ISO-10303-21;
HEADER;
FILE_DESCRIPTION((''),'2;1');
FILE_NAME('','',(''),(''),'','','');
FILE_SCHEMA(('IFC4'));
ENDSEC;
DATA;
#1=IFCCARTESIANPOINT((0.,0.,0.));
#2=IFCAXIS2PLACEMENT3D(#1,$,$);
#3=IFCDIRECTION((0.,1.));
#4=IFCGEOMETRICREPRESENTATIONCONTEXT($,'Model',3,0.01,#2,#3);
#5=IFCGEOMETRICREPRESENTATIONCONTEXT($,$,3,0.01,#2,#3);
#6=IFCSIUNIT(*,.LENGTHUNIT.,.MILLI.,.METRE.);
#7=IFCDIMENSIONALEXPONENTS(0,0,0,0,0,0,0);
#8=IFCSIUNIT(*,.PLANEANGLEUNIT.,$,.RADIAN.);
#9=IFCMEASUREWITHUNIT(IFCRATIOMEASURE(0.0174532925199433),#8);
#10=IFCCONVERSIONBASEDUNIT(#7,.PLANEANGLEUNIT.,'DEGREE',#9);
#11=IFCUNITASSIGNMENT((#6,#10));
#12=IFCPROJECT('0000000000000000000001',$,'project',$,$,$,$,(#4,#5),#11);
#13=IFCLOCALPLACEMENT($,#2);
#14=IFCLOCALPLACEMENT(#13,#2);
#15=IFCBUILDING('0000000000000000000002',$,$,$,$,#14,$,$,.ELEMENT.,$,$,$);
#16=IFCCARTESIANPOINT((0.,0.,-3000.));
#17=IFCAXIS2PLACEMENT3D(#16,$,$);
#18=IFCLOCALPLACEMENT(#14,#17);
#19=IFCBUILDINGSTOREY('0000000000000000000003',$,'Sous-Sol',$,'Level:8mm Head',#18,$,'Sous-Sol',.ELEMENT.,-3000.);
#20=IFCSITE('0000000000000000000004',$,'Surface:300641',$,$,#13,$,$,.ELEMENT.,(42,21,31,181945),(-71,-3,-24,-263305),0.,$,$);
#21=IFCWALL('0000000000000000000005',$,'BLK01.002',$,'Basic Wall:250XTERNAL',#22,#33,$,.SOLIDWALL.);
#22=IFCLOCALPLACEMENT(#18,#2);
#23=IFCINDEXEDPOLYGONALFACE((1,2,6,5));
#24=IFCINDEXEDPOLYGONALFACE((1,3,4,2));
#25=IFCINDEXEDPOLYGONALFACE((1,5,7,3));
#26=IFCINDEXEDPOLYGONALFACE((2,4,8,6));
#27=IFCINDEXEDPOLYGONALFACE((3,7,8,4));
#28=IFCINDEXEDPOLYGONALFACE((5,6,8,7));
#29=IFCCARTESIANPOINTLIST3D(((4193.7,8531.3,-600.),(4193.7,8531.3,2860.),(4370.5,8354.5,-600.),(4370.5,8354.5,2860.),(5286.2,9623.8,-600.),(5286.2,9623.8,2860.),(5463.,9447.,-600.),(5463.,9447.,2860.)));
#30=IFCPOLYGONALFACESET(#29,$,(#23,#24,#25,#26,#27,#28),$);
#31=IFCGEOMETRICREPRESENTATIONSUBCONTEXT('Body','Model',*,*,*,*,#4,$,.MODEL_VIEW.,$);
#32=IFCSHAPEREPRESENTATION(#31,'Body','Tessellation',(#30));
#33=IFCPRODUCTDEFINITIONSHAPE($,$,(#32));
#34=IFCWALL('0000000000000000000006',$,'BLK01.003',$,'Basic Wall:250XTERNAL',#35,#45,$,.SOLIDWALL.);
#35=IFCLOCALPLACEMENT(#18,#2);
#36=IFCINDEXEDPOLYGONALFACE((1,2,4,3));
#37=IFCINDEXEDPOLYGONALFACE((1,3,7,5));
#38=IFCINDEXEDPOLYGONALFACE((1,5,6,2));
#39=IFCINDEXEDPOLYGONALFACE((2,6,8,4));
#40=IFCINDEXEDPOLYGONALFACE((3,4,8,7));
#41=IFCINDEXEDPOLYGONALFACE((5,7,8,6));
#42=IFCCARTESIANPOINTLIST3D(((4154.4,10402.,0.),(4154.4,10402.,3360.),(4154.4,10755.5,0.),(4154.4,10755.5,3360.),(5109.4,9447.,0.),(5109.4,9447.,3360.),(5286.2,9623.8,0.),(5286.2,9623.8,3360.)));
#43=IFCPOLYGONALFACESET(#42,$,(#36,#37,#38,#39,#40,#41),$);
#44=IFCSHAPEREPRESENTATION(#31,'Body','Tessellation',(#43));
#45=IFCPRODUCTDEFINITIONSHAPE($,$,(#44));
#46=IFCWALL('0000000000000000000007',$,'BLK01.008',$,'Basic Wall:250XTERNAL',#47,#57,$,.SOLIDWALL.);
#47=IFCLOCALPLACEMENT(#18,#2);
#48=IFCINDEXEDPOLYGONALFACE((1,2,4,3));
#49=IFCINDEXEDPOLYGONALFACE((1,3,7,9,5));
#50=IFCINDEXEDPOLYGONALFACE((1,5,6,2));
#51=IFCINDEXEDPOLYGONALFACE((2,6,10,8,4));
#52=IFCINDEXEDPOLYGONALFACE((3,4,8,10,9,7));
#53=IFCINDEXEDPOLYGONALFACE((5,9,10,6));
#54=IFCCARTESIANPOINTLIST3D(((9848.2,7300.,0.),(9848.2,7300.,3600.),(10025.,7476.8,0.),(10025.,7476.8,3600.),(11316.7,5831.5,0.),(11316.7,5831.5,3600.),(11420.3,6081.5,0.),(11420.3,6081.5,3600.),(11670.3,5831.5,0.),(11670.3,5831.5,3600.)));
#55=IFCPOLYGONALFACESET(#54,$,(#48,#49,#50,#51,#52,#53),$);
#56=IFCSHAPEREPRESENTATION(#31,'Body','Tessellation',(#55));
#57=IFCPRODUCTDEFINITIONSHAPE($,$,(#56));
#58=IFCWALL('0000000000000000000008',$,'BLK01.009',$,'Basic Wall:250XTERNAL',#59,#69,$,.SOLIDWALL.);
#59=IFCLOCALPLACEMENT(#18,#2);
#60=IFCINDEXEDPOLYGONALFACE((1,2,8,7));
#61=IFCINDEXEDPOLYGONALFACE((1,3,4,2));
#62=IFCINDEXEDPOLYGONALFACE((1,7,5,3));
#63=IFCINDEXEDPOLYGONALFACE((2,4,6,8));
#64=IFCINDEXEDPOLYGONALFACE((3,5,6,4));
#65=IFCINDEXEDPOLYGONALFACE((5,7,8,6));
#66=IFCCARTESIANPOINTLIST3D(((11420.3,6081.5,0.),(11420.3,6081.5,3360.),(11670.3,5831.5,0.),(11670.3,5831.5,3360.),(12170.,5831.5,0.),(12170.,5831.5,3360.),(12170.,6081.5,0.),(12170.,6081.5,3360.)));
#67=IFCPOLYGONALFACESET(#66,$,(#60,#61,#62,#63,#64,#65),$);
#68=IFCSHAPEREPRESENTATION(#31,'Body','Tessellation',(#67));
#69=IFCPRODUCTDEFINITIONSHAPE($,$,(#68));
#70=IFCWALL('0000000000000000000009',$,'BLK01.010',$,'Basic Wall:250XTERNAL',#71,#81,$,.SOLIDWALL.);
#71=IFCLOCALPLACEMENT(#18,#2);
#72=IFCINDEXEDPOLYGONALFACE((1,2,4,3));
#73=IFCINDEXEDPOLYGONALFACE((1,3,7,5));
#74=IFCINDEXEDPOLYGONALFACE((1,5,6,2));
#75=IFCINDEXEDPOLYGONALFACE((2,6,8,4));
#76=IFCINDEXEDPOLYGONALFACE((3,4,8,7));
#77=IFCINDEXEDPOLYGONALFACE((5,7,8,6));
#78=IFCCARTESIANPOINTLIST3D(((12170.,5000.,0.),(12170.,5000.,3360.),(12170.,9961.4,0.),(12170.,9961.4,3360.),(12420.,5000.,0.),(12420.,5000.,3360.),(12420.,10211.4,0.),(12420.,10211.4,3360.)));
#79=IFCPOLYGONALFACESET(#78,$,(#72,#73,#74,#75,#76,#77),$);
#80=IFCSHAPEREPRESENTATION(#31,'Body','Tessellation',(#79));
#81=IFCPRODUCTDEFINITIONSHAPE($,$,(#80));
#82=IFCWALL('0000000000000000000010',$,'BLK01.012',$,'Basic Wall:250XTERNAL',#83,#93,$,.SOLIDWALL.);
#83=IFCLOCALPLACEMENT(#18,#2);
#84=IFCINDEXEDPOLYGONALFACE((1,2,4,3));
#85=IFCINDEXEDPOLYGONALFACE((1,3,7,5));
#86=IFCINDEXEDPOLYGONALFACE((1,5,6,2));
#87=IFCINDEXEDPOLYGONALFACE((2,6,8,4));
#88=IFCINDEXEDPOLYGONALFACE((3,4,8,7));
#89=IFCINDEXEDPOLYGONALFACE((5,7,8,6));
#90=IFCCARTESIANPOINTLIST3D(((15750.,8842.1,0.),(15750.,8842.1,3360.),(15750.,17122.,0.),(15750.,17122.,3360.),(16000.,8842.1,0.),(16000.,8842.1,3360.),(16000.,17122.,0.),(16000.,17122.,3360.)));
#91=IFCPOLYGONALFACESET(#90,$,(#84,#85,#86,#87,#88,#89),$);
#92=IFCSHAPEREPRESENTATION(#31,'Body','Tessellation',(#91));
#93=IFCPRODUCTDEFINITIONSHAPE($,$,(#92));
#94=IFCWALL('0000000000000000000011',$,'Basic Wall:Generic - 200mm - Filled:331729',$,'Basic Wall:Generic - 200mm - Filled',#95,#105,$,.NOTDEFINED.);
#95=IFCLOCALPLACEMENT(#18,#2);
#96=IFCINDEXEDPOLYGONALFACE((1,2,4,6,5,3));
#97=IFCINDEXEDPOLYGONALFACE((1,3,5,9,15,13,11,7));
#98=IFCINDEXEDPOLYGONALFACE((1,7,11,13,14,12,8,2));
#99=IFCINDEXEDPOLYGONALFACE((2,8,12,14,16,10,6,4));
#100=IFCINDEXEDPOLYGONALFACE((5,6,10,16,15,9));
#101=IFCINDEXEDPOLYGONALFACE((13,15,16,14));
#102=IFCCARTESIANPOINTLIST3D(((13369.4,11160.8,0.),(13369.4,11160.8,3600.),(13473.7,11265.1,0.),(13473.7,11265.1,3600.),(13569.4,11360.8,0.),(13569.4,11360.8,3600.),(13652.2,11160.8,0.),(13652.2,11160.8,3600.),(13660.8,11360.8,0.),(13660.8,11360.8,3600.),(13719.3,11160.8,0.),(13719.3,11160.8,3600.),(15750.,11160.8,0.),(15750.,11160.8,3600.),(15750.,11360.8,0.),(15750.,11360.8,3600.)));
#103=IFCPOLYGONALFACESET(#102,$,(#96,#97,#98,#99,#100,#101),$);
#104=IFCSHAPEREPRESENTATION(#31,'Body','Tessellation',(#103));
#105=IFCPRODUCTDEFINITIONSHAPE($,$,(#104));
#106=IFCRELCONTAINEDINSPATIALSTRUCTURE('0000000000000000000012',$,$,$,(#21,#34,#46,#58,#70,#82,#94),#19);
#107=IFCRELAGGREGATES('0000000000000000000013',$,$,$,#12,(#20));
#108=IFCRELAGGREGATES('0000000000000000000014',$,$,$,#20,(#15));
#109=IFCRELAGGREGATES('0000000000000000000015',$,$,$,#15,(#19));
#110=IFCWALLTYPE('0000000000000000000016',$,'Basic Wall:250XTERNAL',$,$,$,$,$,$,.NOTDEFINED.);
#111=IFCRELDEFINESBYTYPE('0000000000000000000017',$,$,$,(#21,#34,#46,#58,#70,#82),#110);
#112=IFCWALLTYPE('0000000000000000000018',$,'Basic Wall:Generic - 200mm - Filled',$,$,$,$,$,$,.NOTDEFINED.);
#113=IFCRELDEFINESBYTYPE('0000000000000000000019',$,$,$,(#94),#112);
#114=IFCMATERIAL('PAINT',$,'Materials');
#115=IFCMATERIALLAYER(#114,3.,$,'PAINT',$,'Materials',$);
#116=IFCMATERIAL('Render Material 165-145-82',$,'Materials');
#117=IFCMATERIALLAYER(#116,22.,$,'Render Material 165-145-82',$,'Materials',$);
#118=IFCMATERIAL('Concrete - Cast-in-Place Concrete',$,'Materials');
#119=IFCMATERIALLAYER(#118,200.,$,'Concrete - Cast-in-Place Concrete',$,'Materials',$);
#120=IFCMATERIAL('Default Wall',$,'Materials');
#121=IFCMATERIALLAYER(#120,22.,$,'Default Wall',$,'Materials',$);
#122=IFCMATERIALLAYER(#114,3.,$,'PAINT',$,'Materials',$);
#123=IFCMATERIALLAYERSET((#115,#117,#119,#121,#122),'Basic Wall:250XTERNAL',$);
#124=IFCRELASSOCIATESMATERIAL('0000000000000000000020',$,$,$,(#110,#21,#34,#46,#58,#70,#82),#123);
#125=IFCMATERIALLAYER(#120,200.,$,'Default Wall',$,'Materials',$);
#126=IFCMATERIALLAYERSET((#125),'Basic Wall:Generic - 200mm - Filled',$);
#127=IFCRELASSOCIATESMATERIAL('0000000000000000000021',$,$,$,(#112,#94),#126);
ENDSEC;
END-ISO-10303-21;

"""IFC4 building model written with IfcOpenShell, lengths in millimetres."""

from ifc_helpers import new_model, entity, si_unit, converted_unit, direction, frame, frame_2d, origin, place, context, subcontext, project, spatial, polyline, rectangle, outline, extrude, clip, halfspace, bounded_halfspace, material, layer, layer_set, layer_usage, type_object, element, save


model = new_model("IFC4")

# Units and contexts
model_context = context("Model", 3, precision=0.01, world=origin(), true_north=direction((0.0, 1.0)))
context_of_model = context(None, 3, precision=0.01, world=origin(), true_north=direction((0.0, 1.0)))
body_context = subcontext(model_context, "Body", "Model", "MODEL_VIEW")
ifc_project = project(units=[si_unit("LENGTHUNIT", "METRE", prefix="MILLI"), converted_unit("PLANEANGLEUNIT", "DEGREE", entity("IfcRatioMeasure", 0.0174532925199433), si_unit("PLANEANGLEUNIT", "RADIAN"), dimensions=[0, 0, 0, 0, 0, 0, 0])], contexts=[model_context, context_of_model])

# Site, building, storey
site_placement = place(None, origin())
site = spatial("IfcSite", under=ifc_project, at=site_placement, Name="Surface:300641", CompositionType="ELEMENT", RefLatitude=(42, 21, 31, 181945), RefLongitude=(-71, -3, -24, -263305), RefElevation=0.0)
building_placement = place(site_placement, origin())
building = spatial("IfcBuilding", under=site, at=building_placement, CompositionType="ELEMENT")
storey_placement = place(building_placement, frame((0.0, 0.0, -3000.0)))
storey = spatial("IfcBuildingStorey", under=building, at=storey_placement, Name="Sous-Sol", ObjectType="Level:8mm Head", LongName="Sous-Sol", CompositionType="ELEMENT", Elevation=-3000.0)

# Walls
ifc_material_1 = material(Name="PAINT", Category="Materials")
ifc_layer_1 = layer(ifc_material_1, 3.0, Name="PAINT", Category="Materials")
ifc_material_2 = material(Name="Render Material 165-145-82", Category="Materials")
ifc_layer_2 = layer(ifc_material_2, 22.0, Name="Render Material 165-145-82", Category="Materials")
ifc_material_3 = material(Name="Concrete - Cast-in-Place Concrete", Category="Materials")
ifc_layer_3 = layer(ifc_material_3, 200.0, Name="Concrete - Cast-in-Place Concrete", Category="Materials")
ifc_material_4 = material(Name="Default Wall", Category="Materials")
ifc_layer_4 = layer(ifc_material_4, 22.0, Name="Default Wall", Category="Materials")
ifc_layer_5 = layer(ifc_material_1, 3.0, Name="PAINT", Category="Materials")
ifc_layer_set_1 = layer_set([ifc_layer_1, ifc_layer_2, ifc_layer_3, ifc_layer_4, ifc_layer_5], Name="Basic Wall:250XTERNAL")
ifc_layer_usage_1 = layer_usage(ifc_layer_set_1, "AXIS2", "NEGATIVE", 125.0)
wall_type_1 = type_object("IfcWallType", Name="Basic Wall:250XTERNAL", PredefinedType="NOTDEFINED", material=ifc_layer_set_1)
wall_1_placement = place(storey_placement, frame((4282.1, 8442.9, -600.0), z_axis=(0.0, 0.0, 1.0), x_axis=(0.707107, 0.707107, 0.0)))
element("IfcWall", 1, at=wall_1_placement, inside=storey, type_object=wall_type_1, material=ifc_layer_usage_1, Name="BLK01.002", ObjectType="Basic Wall:250XTERNAL", PredefinedType="SOLIDWALL", context=body_context, shape_type="Clipping", body=[
    clip(extrude(rectangle(XDim=1545.0, YDim=250.0, at=frame_2d((772.5, 0.0), x_axis=(-1.0, 0.0))), origin(), (0.0, 0.0, 1.0), 3460.0), bounded_halfspace(frame((0.0, -125.0, 3460.0), z_axis=(0.0, 0.0, -1.0), x_axis=(0.707107, -0.707107, 0.0)), True, frame((0.0, -125.0, 3460.0)), polyline([(0.0, 0.0), (1545.0, 0.0), (1545.0, 250.0), (0.0, 250.0), (0.0, 0.0)]))),
])
ifc_layer_usage_2 = layer_usage(ifc_layer_set_1, "AXIS2", "NEGATIVE", 125.0)
wall_2_placement = place(storey_placement, frame((5374.6, 9358.6, 0.0), z_axis=(0.0, 0.0, 1.0), x_axis=(-0.707107, 0.707107, 0.0)))
element("IfcWall", 2, at=wall_2_placement, inside=storey, type_object=wall_type_1, material=ifc_layer_usage_2, Name="BLK01.003", ObjectType="Basic Wall:250XTERNAL", PredefinedType="SOLIDWALL", context=body_context, shape_type="Clipping", body=[
    clip(extrude(outline(polyline([(1850.5, -125.0), (1600.5, 125.0), (250.0, 125.0), (250.0, -125.0), (1850.5, -125.0)])), origin(), (0.0, 0.0, 1.0), 3360.0), bounded_halfspace(frame((250.0, -125.0, 3360.0), z_axis=(0.0, 0.0, -1.0), x_axis=(-0.707107, 0.707107, 0.0)), True, frame((250.0, -125.0, 3360.0)), polyline([(0.0, 0.0), (1600.5, 0.0), (1350.5, 250.0), (0.0, 250.0), (0.0, 0.0)]))),
])

# Walls
ifc_layer_usage_3 = layer_usage(ifc_layer_set_1, "AXIS2", "NEGATIVE", 125.0)
wall_3_placement = place(storey_placement, frame((9936.6, 7388.4, 0.0), z_axis=(0.0, 0.0, 1.0), x_axis=(0.707107, -0.707107, 0.0)))
element("IfcWall", 3, at=wall_3_placement, inside=storey, type_object=wall_type_1, material=ifc_layer_usage_3, Name="BLK01.008", ObjectType="Basic Wall:250XTERNAL", PredefinedType="SOLIDWALL", context=body_context, shape_type="SweptSolid", body=[
    extrude(outline(polyline([(2076.8, -125.0), (2326.8, 125.0), (1973.2, 125.0), (0.0, 125.0), (0.0, -125.0), (2076.8, -125.0)])), origin(), (0.0, 0.0, 1.0), 3600.0),
])
ifc_layer_usage_4 = layer_usage(ifc_layer_set_1, "AXIS2", "NEGATIVE", 125.0)
wall_4_placement = place(storey_placement, frame((11420.3, 5956.5, 0.0)))
element("IfcWall", 4, at=wall_4_placement, inside=storey, type_object=wall_type_1, material=ifc_layer_usage_4, Name="BLK01.009", ObjectType="Basic Wall:250XTERNAL", PredefinedType="SOLIDWALL", context=body_context, shape_type="Clipping", body=[
    clip(extrude(outline(polyline([(749.7, -125.0), (749.7, 125.0), (0.0, 125.0), (250.0, -125.0), (749.7, -125.0)])), origin(), (0.0, 0.0, 1.0), 3360.0), bounded_halfspace(frame((250.0, -125.0, 3360.0), z_axis=(0.0, 0.0, -1.0), x_axis=(0.0, -1.0, 0.0)), True, frame((250.0, -125.0, 3360.0)), polyline([(0.0, 0.0), (499.7, 0.0), (499.7, 250.0), (-250.0, 250.0), (0.0, 0.0)]))),
])
ifc_layer_usage_5 = layer_usage(ifc_layer_set_1, "AXIS2", "NEGATIVE", 125.0)
wall_5_placement = place(storey_placement, frame((12295.0, 5000.0, 0.0), z_axis=(0.0, 0.0, 1.0), x_axis=(0.0, 1.0, 0.0)))
element("IfcWall", 5, at=wall_5_placement, inside=storey, type_object=wall_type_1, material=ifc_layer_usage_5, Name="BLK01.010", ObjectType="Basic Wall:250XTERNAL", PredefinedType="SOLIDWALL", context=body_context, shape_type="Clipping", body=[
    clip(extrude(outline(polyline([(5211.4, -125.0), (4961.4, 125.0), (1081.5, 125.0), (831.5, 125.0), (0.0, 125.0), (0.0, -125.0), (150.0, -125.0), (4928.6, -125.0), (5211.4, -125.0)])), origin(), (0.0, 0.0, 1.0), 3360.0), bounded_halfspace(frame((0.0, -125.0, 3360.0), z_axis=(0.0, 0.0, -1.0), x_axis=(-1.0, 0.0, 0.0)), True, frame((0.0, -125.0, 3360.0)), polyline([(0.0, 0.0), (150.0, 0.0), (5211.4, 0.0), (4961.4, 250.0), (1081.5, 250.0), (831.5, 250.0), (0.0, 250.0), (0.0, 0.0)]))),
])
ifc_layer_usage_6 = layer_usage(ifc_layer_set_1, "AXIS2", "NEGATIVE", 125.0)
wall_6_placement = place(storey_placement, frame((15875.0, 8842.1, 0.0), z_axis=(0.0, 0.0, 1.0), x_axis=(0.0, 1.0, 0.0)))
element("IfcWall", 6, at=wall_6_placement, inside=storey, type_object=wall_type_1, material=ifc_layer_usage_6, Name="BLK01.012", ObjectType="Basic Wall:250XTERNAL", PredefinedType="SOLIDWALL", context=body_context, shape_type="Clipping", body=[
    clip(clip(extrude(rectangle(XDim=8279.9, YDim=250.0, at=frame_2d((4140.0, 0.0), x_axis=(-1.0, 0.0))), origin(), (0.0, 0.0, 1.0), 3360.0), bounded_halfspace(frame((0.0, 125.0, 3360.0), z_axis=(0.0, 0.0, -1.0), x_axis=(-1.0, 0.0, 0.0)), True, frame((0.0, 125.0, 3360.0)), polyline([(0.0, 0.0), (0.0, -250.0), (8279.9, -250.0), (8279.9, 0.0), (0.0, 0.0)]))), halfspace(origin(), True)),
])
ifc_layer_6 = layer(ifc_material_4, 200.0, Name="Default Wall", Category="Materials")
ifc_layer_set_2 = layer_set([ifc_layer_6], Name="Basic Wall:Generic - 200mm - Filled")
ifc_layer_usage_7 = layer_usage(ifc_layer_set_2, "AXIS2", "NEGATIVE", 100.0)
wall_type_2 = type_object("IfcWallType", Name="Basic Wall:Generic - 200mm - Filled", PredefinedType="NOTDEFINED", material=ifc_layer_set_2)
wall_7_placement = place(storey_placement, frame((13369.4, 11260.8, 0.0)))
element("IfcWall", 7, at=wall_7_placement, inside=storey, type_object=wall_type_2, material=ifc_layer_usage_7, Name="Basic Wall:Generic - 200mm - Filled:331729", ObjectType="Basic Wall:Generic - 200mm - Filled", PredefinedType="NOTDEFINED", context=body_context, shape_type="SweptSolid", body=[
    extrude(outline(polyline([(2380.6, -100.0), (2380.6, 100.0), (291.4, 100.0), (200.0, 100.0), (104.3, 4.3), (0.0, -100.0), (282.8, -100.0), (349.9, -100.0), (2380.6, -100.0)])), origin(), (0.0, 0.0, 1.0), 3600.0),
])

save(model, "model.ifc")
